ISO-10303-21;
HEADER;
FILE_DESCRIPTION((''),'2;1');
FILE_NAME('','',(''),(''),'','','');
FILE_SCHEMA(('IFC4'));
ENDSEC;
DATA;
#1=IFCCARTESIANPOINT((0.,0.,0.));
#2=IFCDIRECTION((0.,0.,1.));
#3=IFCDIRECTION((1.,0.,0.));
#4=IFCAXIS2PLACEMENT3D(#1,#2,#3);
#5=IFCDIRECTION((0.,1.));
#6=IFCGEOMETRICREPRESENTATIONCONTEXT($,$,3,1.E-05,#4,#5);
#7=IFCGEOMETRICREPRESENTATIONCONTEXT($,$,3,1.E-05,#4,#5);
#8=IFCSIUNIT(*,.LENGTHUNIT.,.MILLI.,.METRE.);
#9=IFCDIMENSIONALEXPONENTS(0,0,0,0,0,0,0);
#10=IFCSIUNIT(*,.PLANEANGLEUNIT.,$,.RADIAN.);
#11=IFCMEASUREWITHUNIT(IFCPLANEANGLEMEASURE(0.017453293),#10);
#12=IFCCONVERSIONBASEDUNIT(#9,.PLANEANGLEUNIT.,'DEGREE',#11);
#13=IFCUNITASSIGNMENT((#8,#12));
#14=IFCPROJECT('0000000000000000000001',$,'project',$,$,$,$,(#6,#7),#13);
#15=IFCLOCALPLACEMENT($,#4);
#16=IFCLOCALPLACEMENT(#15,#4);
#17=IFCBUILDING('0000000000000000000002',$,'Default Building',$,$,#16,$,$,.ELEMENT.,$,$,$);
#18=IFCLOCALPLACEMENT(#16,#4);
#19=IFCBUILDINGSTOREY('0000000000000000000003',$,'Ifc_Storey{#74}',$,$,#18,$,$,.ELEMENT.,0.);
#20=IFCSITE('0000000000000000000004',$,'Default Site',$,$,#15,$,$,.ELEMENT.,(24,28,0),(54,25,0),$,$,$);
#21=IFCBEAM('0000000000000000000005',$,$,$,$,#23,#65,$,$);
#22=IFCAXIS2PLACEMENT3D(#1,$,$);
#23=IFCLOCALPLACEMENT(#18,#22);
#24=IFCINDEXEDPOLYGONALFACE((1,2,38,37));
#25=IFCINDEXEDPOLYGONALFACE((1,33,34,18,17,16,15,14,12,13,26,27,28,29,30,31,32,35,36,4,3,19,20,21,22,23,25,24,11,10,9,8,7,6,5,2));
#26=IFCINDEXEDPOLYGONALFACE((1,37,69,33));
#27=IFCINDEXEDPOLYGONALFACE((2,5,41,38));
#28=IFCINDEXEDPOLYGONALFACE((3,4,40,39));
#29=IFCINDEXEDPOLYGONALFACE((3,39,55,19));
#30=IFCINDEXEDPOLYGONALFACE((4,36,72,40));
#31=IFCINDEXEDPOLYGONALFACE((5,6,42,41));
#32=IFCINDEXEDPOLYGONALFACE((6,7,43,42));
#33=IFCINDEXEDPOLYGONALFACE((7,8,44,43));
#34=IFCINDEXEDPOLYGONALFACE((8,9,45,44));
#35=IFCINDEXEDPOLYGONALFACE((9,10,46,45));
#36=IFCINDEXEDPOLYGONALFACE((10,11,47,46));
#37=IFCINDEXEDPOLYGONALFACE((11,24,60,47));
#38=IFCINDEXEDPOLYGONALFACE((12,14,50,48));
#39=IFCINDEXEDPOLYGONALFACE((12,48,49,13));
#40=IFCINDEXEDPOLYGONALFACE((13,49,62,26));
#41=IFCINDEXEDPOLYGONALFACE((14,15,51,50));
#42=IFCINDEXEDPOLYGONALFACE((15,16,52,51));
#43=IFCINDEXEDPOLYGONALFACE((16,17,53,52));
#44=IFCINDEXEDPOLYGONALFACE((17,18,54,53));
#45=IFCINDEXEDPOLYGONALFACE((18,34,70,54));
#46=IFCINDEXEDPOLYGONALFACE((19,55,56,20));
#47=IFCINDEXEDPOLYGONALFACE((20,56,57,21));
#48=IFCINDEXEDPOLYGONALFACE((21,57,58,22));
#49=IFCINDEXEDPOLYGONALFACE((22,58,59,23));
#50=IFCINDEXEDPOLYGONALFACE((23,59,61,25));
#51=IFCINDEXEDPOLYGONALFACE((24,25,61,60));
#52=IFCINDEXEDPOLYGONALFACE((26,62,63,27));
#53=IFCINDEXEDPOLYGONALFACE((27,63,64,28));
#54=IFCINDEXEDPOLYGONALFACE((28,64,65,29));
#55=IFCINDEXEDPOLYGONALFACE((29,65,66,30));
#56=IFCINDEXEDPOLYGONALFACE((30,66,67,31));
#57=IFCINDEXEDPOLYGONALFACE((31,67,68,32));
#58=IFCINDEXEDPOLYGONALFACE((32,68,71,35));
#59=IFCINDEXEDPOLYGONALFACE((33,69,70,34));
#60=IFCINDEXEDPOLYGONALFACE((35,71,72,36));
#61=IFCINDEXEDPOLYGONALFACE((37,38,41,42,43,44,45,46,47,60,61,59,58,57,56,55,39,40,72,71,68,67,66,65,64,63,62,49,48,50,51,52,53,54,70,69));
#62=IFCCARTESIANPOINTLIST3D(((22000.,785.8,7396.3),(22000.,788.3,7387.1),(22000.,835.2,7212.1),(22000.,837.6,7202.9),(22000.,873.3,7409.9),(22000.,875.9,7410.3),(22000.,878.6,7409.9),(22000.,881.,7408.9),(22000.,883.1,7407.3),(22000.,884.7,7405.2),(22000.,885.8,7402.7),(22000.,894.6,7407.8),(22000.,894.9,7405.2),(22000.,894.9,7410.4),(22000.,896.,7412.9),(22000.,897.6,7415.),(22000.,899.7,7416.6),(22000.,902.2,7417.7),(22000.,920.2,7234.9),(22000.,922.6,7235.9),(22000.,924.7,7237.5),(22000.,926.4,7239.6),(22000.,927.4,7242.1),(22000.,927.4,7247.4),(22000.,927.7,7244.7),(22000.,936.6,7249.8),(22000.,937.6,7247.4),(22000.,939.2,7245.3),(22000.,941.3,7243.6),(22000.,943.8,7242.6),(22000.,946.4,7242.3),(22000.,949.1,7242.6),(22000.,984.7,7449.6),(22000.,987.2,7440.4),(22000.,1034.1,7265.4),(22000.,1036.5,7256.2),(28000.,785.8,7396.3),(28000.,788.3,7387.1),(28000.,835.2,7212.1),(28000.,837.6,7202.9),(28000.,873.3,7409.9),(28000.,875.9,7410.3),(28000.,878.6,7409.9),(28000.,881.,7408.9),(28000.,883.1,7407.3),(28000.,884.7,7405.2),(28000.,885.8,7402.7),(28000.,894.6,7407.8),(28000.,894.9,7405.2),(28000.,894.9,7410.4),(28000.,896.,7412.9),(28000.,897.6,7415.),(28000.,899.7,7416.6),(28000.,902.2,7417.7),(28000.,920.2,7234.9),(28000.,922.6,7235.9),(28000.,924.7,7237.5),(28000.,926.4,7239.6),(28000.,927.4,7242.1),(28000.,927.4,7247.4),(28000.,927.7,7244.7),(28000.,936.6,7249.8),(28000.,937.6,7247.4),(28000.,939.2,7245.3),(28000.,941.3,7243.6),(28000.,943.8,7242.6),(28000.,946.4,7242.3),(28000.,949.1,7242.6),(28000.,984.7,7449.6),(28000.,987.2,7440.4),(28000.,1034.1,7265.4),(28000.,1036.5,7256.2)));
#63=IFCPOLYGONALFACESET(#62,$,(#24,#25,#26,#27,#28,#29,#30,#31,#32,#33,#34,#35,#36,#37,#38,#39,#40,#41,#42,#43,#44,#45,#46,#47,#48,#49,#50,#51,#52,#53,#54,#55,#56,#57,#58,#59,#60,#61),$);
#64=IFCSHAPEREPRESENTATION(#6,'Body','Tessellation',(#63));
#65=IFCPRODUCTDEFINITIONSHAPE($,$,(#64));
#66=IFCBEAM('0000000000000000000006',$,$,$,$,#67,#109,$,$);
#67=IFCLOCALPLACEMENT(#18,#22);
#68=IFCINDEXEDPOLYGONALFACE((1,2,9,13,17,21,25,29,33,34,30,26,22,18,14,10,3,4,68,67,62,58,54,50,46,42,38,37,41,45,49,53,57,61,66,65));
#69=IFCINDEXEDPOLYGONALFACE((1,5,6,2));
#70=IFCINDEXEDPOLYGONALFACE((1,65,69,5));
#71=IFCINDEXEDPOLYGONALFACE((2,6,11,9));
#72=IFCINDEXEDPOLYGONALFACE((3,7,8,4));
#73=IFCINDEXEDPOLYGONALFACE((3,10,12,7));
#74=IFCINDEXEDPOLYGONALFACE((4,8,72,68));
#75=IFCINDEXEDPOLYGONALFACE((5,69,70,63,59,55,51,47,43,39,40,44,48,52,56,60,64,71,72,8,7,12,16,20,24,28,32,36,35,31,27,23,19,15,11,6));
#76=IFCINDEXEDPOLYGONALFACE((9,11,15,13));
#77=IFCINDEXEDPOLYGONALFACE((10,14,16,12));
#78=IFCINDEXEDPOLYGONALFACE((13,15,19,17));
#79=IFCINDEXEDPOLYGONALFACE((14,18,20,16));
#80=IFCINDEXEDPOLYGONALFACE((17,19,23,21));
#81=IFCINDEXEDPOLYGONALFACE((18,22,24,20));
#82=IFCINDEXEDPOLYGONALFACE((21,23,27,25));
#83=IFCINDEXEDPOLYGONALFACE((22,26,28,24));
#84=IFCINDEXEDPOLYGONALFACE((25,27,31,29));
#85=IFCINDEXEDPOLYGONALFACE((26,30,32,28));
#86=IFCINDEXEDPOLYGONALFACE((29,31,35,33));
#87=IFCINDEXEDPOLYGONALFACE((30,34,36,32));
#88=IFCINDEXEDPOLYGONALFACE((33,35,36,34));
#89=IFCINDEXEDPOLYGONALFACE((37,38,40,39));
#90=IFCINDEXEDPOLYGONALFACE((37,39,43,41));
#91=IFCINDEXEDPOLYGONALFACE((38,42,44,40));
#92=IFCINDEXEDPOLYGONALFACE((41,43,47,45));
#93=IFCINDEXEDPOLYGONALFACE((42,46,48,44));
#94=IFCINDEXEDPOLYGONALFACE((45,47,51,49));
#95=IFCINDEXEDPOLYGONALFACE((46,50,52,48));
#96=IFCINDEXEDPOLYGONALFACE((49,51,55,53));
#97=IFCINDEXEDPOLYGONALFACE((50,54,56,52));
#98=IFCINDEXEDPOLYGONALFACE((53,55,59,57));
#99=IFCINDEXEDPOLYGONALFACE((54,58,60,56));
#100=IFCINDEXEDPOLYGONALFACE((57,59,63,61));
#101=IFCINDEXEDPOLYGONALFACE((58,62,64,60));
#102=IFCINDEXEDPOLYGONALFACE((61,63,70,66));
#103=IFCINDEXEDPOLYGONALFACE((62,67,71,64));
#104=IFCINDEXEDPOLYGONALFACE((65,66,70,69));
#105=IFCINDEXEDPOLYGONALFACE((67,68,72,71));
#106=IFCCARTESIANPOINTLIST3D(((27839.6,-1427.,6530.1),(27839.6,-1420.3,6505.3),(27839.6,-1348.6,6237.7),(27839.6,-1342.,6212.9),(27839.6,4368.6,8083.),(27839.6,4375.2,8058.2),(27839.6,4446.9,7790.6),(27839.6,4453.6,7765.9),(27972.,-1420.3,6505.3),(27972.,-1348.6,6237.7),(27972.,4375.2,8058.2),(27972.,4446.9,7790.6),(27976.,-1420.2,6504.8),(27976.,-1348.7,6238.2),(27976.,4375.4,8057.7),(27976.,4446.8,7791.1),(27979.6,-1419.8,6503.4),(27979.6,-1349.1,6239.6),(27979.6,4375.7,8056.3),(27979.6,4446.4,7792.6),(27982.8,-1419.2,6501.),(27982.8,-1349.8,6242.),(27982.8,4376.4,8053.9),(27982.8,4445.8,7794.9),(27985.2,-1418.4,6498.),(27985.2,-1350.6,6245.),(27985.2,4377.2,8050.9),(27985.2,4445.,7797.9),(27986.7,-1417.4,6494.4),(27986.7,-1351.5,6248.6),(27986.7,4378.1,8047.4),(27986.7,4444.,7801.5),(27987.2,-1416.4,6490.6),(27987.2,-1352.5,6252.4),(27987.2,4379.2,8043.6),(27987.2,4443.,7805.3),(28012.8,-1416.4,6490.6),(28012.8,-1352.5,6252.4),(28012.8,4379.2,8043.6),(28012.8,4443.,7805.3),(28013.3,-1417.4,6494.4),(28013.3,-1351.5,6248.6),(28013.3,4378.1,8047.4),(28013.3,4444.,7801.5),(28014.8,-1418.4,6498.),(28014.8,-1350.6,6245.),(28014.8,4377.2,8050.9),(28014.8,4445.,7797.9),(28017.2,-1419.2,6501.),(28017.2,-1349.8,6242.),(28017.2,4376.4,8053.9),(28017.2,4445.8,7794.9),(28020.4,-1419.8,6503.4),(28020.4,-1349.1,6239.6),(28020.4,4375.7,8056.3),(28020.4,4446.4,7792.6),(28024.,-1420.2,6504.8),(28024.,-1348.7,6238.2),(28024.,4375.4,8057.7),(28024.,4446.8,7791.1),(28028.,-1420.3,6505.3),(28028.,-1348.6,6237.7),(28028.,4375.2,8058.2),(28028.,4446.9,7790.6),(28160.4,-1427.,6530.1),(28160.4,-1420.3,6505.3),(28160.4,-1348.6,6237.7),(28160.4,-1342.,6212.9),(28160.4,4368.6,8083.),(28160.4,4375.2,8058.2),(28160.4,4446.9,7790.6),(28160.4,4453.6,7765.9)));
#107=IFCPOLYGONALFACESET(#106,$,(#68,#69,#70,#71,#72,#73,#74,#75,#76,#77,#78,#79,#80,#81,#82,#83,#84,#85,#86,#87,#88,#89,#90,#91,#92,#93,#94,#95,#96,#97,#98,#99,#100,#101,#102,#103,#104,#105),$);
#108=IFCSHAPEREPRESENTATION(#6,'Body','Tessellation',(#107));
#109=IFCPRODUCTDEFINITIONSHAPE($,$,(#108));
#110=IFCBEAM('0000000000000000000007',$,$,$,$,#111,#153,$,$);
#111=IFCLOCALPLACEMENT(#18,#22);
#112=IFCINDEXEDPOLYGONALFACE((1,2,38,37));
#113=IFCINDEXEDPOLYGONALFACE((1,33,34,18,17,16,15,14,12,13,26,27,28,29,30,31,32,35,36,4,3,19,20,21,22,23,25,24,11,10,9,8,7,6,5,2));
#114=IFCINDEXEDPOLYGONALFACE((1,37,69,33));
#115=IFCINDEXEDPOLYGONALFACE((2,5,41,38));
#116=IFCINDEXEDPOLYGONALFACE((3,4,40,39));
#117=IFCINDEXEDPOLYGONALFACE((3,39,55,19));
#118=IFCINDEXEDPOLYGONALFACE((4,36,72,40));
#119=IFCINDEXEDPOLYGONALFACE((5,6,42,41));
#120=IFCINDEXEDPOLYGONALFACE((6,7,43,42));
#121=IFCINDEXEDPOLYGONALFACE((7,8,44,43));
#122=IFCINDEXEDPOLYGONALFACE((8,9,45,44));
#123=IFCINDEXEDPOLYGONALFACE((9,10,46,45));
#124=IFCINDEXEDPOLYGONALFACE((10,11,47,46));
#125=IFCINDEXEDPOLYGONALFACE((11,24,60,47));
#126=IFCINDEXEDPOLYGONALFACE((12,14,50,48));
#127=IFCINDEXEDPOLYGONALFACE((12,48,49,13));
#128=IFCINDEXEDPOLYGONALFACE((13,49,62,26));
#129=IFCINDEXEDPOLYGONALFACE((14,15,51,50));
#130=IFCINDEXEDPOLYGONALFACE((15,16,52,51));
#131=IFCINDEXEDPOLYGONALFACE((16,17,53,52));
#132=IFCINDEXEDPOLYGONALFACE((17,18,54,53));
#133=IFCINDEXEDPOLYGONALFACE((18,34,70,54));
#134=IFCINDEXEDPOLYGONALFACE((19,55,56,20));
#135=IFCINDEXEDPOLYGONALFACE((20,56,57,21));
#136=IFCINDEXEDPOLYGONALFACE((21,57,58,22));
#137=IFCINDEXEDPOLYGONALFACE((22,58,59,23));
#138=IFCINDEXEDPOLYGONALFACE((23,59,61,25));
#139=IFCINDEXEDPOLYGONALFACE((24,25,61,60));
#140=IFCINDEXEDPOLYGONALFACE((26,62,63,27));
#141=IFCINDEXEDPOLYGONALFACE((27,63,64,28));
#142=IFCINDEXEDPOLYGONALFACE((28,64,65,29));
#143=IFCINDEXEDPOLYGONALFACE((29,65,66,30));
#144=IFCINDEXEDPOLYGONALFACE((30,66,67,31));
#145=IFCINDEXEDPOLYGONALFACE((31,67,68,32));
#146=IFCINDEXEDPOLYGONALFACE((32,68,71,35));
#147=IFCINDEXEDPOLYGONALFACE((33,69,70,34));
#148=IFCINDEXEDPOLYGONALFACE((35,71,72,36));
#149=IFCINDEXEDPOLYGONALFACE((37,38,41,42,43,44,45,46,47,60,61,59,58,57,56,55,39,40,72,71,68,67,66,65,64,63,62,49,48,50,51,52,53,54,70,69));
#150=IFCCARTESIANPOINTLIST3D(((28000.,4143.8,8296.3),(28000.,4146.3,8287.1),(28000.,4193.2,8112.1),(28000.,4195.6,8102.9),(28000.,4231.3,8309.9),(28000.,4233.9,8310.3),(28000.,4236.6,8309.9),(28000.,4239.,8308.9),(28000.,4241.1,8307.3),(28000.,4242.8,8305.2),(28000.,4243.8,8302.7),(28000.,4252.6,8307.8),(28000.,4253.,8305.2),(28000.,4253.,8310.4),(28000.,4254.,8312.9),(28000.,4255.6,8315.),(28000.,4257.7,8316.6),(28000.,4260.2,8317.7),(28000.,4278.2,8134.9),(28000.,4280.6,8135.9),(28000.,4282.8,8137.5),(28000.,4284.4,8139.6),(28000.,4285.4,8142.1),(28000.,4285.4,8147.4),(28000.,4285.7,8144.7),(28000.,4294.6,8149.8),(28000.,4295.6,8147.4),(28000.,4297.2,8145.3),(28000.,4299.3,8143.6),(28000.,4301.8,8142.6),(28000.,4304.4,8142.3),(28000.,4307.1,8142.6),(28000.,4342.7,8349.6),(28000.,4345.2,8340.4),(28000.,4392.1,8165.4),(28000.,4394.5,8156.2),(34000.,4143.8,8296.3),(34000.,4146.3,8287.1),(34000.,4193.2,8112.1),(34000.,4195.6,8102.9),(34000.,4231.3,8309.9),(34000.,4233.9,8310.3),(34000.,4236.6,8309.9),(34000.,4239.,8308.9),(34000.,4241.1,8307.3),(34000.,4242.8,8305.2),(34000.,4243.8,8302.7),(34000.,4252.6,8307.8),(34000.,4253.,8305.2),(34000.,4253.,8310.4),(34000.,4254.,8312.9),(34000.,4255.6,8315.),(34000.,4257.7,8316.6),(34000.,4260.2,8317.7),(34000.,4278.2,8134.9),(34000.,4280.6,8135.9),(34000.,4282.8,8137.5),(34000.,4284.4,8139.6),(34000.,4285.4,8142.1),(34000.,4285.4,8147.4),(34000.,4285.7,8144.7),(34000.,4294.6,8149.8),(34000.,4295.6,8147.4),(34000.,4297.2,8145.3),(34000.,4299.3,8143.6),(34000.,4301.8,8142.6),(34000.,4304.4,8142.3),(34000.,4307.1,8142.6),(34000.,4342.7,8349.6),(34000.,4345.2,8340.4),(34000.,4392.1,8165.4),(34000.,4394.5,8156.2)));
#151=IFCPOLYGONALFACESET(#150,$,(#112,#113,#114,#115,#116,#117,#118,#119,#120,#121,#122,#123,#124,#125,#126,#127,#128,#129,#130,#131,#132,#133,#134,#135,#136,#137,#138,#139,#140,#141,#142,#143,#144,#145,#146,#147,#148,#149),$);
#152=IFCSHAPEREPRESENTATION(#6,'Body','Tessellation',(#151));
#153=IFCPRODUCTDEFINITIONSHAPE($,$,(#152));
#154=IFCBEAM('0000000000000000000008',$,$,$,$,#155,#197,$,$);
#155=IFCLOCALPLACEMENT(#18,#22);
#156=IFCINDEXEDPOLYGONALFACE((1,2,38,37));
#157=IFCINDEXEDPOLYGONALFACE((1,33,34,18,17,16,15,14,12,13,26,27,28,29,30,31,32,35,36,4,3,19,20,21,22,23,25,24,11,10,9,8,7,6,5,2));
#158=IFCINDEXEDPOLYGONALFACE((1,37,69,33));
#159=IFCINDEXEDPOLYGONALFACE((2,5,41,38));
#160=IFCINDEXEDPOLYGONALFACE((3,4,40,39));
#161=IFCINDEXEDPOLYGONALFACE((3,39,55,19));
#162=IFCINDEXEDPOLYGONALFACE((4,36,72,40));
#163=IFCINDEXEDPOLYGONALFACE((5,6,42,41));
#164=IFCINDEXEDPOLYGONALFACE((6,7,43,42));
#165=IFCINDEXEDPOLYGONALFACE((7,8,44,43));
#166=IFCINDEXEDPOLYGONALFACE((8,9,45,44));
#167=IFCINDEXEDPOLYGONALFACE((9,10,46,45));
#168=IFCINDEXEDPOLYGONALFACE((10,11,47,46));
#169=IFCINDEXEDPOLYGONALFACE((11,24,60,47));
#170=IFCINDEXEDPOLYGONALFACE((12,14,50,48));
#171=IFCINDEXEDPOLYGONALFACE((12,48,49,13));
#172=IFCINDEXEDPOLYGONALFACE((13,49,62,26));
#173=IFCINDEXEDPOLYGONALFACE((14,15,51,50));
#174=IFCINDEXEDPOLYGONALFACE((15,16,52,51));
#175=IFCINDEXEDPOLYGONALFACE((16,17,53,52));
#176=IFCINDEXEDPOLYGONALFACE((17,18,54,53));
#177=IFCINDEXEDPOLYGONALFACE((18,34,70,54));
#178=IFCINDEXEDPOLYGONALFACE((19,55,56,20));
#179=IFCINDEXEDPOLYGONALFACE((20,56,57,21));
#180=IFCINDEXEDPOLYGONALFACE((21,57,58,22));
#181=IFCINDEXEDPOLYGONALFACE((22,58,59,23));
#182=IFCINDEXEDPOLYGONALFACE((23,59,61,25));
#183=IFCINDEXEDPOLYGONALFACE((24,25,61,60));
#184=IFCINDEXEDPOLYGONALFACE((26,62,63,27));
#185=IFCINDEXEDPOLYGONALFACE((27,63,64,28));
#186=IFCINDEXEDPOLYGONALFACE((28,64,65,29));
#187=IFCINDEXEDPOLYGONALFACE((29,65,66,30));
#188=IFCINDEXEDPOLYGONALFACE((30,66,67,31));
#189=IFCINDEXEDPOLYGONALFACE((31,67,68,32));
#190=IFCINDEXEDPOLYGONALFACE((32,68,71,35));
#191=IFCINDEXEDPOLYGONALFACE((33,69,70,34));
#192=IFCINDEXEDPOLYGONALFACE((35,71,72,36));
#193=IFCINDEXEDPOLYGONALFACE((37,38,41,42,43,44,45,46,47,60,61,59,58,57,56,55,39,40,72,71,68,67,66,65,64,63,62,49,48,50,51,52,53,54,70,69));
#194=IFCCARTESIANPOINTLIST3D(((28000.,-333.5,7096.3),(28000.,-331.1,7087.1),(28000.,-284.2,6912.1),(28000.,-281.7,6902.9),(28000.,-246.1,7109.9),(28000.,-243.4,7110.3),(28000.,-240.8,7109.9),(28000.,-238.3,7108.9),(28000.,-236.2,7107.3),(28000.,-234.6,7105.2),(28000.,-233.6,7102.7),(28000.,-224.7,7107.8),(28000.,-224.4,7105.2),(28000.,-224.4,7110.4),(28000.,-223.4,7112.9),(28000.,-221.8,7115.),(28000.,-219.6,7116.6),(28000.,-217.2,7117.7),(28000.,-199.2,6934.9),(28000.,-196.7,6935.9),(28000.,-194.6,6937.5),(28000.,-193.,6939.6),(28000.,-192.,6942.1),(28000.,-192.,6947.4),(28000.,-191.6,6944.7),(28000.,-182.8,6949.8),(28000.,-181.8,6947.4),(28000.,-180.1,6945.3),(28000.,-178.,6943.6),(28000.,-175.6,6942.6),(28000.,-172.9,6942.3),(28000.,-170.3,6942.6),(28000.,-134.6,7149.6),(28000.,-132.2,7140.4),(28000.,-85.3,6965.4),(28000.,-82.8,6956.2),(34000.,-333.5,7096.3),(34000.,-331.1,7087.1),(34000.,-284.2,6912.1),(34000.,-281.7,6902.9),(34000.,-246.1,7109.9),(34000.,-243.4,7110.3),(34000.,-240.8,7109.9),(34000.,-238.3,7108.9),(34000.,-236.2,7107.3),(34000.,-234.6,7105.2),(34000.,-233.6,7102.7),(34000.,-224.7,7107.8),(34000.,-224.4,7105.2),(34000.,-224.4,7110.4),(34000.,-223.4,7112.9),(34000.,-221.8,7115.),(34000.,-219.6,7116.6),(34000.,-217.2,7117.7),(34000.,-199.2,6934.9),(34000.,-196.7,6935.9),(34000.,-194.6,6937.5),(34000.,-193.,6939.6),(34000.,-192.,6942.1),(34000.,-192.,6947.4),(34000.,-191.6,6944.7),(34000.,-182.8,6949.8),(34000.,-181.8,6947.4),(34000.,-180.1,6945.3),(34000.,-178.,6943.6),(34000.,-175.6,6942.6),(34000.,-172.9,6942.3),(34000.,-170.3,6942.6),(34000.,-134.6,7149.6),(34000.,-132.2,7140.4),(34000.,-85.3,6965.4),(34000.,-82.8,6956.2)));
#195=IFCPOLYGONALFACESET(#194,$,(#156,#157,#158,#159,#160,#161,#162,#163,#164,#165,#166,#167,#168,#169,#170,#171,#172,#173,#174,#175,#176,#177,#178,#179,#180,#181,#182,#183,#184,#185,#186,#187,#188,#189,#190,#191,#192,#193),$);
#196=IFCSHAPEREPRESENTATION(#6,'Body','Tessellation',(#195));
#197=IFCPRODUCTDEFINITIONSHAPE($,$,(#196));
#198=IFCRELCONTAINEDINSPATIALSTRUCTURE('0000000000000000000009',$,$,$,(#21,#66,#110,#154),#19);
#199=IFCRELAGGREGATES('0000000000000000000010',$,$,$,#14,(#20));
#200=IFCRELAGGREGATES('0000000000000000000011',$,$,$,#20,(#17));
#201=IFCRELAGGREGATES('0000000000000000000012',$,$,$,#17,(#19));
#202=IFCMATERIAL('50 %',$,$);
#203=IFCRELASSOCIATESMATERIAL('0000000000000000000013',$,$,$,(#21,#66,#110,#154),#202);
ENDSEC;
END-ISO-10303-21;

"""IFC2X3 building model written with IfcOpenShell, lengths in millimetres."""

from ifc_helpers import new_model, entity, si_unit, converted_unit, direction, frame, origin_with_axes, origin_2d_with_axis, place, context, project, spatial, i_section, extrude, material, element, save


model = new_model("IFC2X3")

# Units and contexts
context_of_model_1 = context(None, 3, precision=1e-05, world=origin_with_axes(), true_north=direction((0.0, 1.0)))
context_of_model_2 = context(None, 3, precision=1e-05, world=origin_with_axes(), true_north=direction((0.0, 1.0)))
ifc_project = project(units=[si_unit("LENGTHUNIT", "METRE", prefix="MILLI"), converted_unit("PLANEANGLEUNIT", "DEGREE", entity("IfcPlaneAngleMeasure", 0.017453293), si_unit("PLANEANGLEUNIT", "RADIAN"), dimensions=[0, 0, 0, 0, 0, 0, 0])], contexts=[context_of_model_1, context_of_model_2])

# Site, building, storey
site_placement = place(None, origin_with_axes())
site = spatial("IfcSite", under=ifc_project, at=site_placement, Name="Default Site", CompositionType="ELEMENT", RefLatitude=(24, 28, 0), RefLongitude=(54, 25, 0))
building_placement = place(site_placement, origin_with_axes())
building = spatial("IfcBuilding", under=site, at=building_placement, Name="Default Building", CompositionType="ELEMENT")
storey_placement = place(building_placement, origin_with_axes())
storey = spatial("IfcBuildingStorey", under=building, at=storey_placement, Name="Ifc_Storey{#74}", CompositionType="ELEMENT", Elevation=0.0)

# Shared definitions
ifc_material_1 = material(Name="50 %")

# Beams
for number, where, z_axis, x_axis in (
    (1, (22000.0, 911.2, 7326.3), (0.0, -0.258819, 0.965926), (-1.0, 0.0, 0.0)),
):
    element("IfcBeam", number, at=place(storey_placement, frame(where, z_axis=z_axis, x_axis=x_axis)), inside=storey, material=ifc_material_1, context=context_of_model_1, shape_type="SweptSolid", body=[
        extrude(i_section(OverallWidth=205.9, OverallDepth=200.2, WebThickness=9.5, FlangeThickness=9.5, FilletRadius=10.2, at=origin_2d_with_axis()), frame((0.0, 0.0, 0.0), z_axis=(-1.0, 0.0, 0.0), x_axis=(0.0, 1.0, 0.0)), (0.0, 0.0, 1.0), 6000.0),
    ])
beam_1_placement = place(storey_placement, frame((28000.0, -1384.5, 6371.5), z_axis=(0.0, 0.0, 1.0), x_axis=(0.0, -1.0, 0.0)))
element("IfcBeam", 2, at=beam_1_placement, inside=storey, material=ifc_material_1, context=context_of_model_1, shape_type="SweptSolid", body=[
    extrude(i_section(OverallWidth=320.9, OverallDepth=328.3, WebThickness=25.5, FlangeThickness=25.6, FilletRadius=15.2, at=origin_2d_with_axis()), frame((0.0, 0.0, 0.0), z_axis=(-0.965926, 0.0, 0.258819), x_axis=(0.0, 1.0, 0.0)), (0.0, 0.0, 1.0), 6000.0),
])
for number, where, z_axis, x_axis in (
    (3, (28000.0, 4269.2, 8226.3), (0.0, -0.258819, 0.965926), (-1.0, 0.0, 0.0)),
    (4, (28000.0, -208.2, 7026.3), (0.0, -0.258819, 0.965926), (-1.0, 0.0, 0.0)),
):
    element("IfcBeam", number, at=place(storey_placement, frame(where, z_axis=z_axis, x_axis=x_axis)), inside=storey, material=ifc_material_1, context=context_of_model_1, shape_type="SweptSolid", body=[
        extrude(i_section(OverallWidth=205.9, OverallDepth=200.2, WebThickness=9.5, FlangeThickness=9.5, FilletRadius=10.2, at=origin_2d_with_axis()), frame((0.0, 0.0, 0.0), z_axis=(-1.0, 0.0, 0.0), x_axis=(0.0, 1.0, 0.0)), (0.0, 0.0, 1.0), 6000.0),
    ])

save(model, "model.ifc")
